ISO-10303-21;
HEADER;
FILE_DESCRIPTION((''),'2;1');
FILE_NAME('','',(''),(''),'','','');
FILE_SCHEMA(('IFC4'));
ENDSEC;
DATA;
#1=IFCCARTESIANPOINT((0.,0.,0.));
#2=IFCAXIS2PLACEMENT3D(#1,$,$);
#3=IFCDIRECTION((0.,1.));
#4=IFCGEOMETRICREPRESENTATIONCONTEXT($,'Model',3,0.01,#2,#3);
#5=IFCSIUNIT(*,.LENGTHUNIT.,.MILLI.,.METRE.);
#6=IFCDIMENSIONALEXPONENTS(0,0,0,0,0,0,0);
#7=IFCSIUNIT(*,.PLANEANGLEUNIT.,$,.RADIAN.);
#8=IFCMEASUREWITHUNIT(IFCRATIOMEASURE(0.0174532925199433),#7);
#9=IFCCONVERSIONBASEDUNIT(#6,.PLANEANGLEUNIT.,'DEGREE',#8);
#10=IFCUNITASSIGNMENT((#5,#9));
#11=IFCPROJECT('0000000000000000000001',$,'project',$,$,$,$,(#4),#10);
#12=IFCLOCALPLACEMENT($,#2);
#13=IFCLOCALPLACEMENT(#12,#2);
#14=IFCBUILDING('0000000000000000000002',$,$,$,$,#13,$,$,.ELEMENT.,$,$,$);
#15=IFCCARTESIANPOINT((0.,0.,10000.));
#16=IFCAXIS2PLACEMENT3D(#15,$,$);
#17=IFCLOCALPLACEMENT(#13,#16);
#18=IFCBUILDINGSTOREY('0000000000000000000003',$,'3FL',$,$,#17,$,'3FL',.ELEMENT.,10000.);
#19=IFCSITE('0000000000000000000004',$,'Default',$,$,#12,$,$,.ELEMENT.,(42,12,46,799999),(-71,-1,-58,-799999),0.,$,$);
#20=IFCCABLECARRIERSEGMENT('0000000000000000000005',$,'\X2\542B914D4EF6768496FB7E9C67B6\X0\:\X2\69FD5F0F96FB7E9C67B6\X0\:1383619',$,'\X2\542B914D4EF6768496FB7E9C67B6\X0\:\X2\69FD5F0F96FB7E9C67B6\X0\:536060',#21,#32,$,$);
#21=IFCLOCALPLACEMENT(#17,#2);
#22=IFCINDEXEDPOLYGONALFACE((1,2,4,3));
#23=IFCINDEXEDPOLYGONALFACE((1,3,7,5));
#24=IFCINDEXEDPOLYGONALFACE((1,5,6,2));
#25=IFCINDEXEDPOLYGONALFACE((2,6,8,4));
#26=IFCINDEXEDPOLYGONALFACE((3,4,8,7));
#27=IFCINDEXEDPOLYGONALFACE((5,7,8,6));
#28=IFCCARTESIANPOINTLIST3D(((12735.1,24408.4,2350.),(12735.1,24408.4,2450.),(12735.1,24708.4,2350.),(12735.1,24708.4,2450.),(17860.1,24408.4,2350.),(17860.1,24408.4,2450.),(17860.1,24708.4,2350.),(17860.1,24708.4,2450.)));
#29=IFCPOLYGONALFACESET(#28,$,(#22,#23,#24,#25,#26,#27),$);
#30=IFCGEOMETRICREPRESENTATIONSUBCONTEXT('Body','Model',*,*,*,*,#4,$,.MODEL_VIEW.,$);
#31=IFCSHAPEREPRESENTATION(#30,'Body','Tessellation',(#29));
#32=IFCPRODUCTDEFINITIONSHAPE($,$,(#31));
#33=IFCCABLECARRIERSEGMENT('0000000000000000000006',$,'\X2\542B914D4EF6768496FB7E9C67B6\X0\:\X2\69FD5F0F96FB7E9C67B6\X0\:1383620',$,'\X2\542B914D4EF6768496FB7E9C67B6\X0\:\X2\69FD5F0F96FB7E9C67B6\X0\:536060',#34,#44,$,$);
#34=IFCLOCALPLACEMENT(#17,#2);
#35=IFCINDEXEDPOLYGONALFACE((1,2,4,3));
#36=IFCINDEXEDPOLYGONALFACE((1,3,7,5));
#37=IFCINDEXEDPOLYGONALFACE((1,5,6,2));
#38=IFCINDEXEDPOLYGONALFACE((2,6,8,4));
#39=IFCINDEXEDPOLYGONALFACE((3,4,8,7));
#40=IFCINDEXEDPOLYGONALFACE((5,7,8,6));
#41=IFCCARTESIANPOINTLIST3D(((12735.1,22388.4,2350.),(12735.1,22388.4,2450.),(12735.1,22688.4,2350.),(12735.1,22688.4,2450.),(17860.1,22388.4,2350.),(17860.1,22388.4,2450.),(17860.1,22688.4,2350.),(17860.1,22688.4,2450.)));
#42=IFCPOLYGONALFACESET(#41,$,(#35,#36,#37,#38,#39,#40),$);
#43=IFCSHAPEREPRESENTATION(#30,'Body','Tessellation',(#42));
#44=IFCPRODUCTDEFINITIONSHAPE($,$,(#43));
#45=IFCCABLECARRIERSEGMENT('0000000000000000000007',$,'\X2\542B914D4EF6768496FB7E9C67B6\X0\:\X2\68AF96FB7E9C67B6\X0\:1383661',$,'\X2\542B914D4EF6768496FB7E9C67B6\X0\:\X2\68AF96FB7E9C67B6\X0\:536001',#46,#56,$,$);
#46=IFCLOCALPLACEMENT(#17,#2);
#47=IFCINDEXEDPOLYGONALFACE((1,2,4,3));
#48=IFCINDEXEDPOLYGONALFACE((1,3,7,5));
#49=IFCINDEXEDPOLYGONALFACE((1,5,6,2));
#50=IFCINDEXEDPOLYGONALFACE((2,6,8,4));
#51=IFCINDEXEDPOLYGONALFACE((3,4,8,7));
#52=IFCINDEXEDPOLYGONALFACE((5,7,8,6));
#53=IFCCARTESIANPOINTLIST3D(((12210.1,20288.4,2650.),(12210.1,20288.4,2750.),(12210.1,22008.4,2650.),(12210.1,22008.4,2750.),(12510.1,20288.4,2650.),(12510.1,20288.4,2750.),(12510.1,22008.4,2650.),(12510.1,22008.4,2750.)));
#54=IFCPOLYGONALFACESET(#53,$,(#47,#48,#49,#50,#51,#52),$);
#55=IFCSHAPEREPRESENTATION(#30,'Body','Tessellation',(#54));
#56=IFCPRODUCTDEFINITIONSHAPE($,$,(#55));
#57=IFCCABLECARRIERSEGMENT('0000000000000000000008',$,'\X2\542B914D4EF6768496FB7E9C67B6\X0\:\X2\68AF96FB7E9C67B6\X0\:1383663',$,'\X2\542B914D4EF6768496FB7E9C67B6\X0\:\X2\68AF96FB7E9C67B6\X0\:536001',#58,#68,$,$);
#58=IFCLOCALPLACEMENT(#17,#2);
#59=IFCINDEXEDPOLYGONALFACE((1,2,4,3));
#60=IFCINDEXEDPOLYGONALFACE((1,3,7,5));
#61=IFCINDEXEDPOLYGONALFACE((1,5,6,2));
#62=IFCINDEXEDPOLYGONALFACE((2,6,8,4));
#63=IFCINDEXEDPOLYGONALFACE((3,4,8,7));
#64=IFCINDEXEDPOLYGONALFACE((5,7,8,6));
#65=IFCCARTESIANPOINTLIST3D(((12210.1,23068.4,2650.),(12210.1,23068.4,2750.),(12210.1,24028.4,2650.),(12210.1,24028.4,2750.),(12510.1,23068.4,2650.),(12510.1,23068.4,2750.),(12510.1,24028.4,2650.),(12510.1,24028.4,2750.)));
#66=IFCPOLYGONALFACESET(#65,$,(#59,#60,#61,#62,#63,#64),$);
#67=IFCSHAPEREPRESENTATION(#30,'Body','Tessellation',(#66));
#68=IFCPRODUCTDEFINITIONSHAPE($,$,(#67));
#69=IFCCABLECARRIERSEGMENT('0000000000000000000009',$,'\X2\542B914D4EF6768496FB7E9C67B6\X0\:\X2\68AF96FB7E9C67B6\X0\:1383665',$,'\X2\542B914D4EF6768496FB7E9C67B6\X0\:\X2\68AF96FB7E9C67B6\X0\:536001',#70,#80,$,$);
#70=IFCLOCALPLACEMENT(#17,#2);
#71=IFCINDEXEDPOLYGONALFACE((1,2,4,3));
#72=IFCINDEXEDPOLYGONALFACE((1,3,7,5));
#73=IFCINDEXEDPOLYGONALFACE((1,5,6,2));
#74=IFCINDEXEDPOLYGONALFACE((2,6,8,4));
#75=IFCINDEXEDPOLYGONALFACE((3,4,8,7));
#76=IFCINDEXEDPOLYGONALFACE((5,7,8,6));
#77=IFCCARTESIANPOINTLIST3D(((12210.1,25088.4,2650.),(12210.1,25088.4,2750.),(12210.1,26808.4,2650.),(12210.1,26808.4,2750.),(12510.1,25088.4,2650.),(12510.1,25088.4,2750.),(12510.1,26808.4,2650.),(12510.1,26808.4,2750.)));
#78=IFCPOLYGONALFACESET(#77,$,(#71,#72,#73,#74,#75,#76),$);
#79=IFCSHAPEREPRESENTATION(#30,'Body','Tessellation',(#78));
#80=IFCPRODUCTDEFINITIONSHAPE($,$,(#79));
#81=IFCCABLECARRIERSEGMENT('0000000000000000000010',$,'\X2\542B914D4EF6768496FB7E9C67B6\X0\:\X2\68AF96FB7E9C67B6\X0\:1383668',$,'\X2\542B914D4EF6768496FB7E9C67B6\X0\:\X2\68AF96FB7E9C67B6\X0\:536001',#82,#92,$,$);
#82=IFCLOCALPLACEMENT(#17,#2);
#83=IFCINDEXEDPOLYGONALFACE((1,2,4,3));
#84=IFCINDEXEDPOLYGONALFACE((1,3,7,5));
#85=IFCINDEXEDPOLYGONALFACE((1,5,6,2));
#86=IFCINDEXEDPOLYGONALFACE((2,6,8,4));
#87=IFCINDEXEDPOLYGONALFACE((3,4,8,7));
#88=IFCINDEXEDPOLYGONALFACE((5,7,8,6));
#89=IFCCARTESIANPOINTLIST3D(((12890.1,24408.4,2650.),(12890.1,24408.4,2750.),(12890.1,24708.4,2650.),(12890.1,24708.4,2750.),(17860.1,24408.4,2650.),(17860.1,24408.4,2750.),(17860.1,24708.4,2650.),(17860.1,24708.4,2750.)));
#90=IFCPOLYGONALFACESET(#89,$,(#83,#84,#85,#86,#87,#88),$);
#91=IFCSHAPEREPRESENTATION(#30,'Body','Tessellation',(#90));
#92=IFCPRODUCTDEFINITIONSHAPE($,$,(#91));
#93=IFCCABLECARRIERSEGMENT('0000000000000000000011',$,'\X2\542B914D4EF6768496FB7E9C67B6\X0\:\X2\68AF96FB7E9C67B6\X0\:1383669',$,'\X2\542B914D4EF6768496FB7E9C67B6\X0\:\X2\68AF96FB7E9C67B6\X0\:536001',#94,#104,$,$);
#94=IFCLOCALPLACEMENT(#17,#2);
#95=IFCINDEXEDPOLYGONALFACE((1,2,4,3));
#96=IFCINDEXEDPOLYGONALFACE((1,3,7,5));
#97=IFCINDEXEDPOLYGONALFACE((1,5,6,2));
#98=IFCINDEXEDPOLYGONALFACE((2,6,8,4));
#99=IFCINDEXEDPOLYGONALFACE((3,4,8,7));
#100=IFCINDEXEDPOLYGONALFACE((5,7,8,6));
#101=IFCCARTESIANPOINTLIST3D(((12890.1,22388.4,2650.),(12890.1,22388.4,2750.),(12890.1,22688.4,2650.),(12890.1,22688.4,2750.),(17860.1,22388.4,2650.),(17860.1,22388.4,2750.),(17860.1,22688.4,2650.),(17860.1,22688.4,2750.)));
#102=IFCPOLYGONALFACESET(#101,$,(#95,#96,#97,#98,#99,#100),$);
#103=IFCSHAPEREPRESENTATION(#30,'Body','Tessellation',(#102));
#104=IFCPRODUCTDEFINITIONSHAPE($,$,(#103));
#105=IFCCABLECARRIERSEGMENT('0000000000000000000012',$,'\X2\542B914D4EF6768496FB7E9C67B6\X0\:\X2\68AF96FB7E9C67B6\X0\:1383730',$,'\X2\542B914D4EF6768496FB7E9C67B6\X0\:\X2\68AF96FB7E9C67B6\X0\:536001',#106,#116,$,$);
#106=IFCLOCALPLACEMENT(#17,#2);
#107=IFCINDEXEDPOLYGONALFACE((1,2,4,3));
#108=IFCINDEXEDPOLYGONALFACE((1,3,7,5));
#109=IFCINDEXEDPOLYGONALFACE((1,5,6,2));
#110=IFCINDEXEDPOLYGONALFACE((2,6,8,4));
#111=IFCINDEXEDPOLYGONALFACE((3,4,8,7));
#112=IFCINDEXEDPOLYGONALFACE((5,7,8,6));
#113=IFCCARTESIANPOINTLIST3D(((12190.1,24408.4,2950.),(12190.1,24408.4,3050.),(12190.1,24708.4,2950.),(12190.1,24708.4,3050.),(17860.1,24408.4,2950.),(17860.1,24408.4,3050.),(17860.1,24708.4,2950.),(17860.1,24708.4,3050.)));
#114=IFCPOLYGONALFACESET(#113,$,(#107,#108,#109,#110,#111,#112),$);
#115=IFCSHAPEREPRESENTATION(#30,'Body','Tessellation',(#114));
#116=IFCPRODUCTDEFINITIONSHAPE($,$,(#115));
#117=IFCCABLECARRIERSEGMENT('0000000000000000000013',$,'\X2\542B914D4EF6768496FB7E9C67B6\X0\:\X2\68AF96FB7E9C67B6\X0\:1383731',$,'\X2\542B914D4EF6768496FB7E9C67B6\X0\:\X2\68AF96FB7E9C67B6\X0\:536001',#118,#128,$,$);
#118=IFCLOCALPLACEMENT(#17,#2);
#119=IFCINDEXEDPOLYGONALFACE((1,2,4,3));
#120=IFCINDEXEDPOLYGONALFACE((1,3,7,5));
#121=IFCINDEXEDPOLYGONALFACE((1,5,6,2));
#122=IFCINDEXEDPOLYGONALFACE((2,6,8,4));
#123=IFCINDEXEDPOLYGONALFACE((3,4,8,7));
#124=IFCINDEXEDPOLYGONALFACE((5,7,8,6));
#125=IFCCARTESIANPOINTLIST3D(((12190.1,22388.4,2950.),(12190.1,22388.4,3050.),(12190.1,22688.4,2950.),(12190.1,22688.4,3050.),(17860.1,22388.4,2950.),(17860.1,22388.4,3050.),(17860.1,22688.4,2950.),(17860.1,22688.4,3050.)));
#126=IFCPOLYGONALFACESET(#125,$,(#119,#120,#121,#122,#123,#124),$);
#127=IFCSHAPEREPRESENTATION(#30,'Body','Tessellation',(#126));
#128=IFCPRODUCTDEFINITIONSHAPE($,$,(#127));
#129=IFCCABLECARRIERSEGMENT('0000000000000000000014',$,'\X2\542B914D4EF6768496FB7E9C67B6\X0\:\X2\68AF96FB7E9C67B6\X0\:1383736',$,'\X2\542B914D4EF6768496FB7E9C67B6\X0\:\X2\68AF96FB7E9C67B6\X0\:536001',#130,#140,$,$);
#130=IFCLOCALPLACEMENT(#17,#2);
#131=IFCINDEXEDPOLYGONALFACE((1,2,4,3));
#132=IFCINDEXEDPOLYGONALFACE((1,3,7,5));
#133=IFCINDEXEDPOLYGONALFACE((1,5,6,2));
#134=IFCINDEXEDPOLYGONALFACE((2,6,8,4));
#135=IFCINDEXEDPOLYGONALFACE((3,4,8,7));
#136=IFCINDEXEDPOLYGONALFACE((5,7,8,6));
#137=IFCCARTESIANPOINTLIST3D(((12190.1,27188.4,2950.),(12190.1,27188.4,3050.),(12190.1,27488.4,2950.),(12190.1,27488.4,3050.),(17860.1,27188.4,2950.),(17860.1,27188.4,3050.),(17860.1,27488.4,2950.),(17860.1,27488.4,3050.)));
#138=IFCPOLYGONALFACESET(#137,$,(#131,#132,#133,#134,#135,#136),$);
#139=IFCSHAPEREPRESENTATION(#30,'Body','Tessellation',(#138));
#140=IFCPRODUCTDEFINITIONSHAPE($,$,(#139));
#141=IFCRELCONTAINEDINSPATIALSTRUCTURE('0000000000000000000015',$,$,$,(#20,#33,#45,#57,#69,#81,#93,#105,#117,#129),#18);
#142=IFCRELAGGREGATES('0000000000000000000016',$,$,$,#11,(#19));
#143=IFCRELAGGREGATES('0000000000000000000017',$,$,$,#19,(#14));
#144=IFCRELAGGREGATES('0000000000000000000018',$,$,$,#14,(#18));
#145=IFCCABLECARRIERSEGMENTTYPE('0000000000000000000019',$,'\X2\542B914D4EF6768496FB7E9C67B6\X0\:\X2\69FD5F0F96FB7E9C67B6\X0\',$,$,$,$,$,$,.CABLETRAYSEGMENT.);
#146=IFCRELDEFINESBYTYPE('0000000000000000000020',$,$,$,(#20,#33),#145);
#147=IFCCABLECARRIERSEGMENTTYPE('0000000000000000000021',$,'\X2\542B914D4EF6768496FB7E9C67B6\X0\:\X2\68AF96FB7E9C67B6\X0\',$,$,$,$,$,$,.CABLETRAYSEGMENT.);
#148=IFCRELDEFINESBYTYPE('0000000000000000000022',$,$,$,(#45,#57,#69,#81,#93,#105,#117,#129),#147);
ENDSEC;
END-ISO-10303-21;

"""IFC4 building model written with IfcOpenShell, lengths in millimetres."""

from ifc_helpers import new_model, entity, si_unit, converted_unit, direction, frame, frame_2d, origin, place, context, subcontext, project, spatial, rectangle, extrude, type_object, element, save


model = new_model("IFC4")

# Units and contexts
model_context = context("Model", 3, precision=0.01, world=origin(), true_north=direction((0.0, 1.0)))
body_context = subcontext(model_context, "Body", "Model", "MODEL_VIEW")
ifc_project = project(units=[si_unit("LENGTHUNIT", "METRE", prefix="MILLI"), converted_unit("PLANEANGLEUNIT", "DEGREE", entity("IfcRatioMeasure", 0.0174532925199433), si_unit("PLANEANGLEUNIT", "RADIAN"), dimensions=[0, 0, 0, 0, 0, 0, 0])], contexts=[model_context])

# Site, building, storey
site_placement = place(None, origin())
site = spatial("IfcSite", under=ifc_project, at=site_placement, Name="Default", CompositionType="ELEMENT", RefLatitude=(42, 12, 46, 799999), RefLongitude=(-71, -1, -58, -799999), RefElevation=0.0)
building_placement = place(site_placement, origin())
building = spatial("IfcBuilding", under=site, at=building_placement, CompositionType="ELEMENT")
storey_placement = place(building_placement, frame((0.0, 0.0, 10000.0)))
storey = spatial("IfcBuildingStorey", under=building, at=storey_placement, Name="3FL", LongName="3FL", CompositionType="ELEMENT", Elevation=10000.0)

# Cable carrier segments
cable_carrier_segment_type_1 = type_object("IfcCableCarrierSegmentType", Name="含配件的電纜架:槽式電纜架", PredefinedType="CABLETRAYSEGMENT")
cable_carrier_segment_1_placement = place(storey_placement, frame((12735.1, 24408.4, 2350.0)))
element("IfcCableCarrierSegment", 1, at=cable_carrier_segment_1_placement, inside=storey, type_object=cable_carrier_segment_type_1, Name="含配件的電纜架:槽式電纜架:1383619", ObjectType="含配件的電纜架:槽式電纜架:536060", context=body_context, shape_type="SweptSolid", body=[
    extrude(rectangle(XDim=5125.0, YDim=300.0, at=frame_2d((0.0, 0.0), x_axis=(1.0, 0.0))), frame((2562.5, 150.0, 0.0), z_axis=(0.0, 0.0, 1.0), x_axis=(-1.0, 0.0, 0.0)), (0.0, 0.0, 1.0), 100.0),
])
cable_carrier_segment_2_placement = place(storey_placement, frame((12735.1, 22388.4, 2350.0)))
element("IfcCableCarrierSegment", 2, at=cable_carrier_segment_2_placement, inside=storey, type_object=cable_carrier_segment_type_1, Name="含配件的電纜架:槽式電纜架:1383620", ObjectType="含配件的電纜架:槽式電纜架:536060", context=body_context, shape_type="SweptSolid", body=[
    extrude(rectangle(XDim=5125.0, YDim=300.0, at=frame_2d((0.0, 0.0), x_axis=(1.0, 0.0))), frame((2562.5, 150.0, 0.0), z_axis=(0.0, 0.0, 1.0), x_axis=(-1.0, 0.0, 0.0)), (0.0, 0.0, 1.0), 100.0),
])
cable_carrier_segment_type_2 = type_object("IfcCableCarrierSegmentType", Name="含配件的電纜架:梯電纜架", PredefinedType="CABLETRAYSEGMENT")
cable_carrier_segment_3_placement = place(storey_placement, frame((12210.1, 20288.4, 2650.0)))
element("IfcCableCarrierSegment", 3, at=cable_carrier_segment_3_placement, inside=storey, type_object=cable_carrier_segment_type_2, Name="含配件的電纜架:梯電纜架:1383661", ObjectType="含配件的電纜架:梯電纜架:536001", context=body_context, shape_type="SweptSolid", body=[
    extrude(rectangle(XDim=1720.0, YDim=300.0, at=frame_2d((0.0, 0.0), x_axis=(1.0, 0.0))), frame((150.0, 860.0, 0.0), z_axis=(0.0, 0.0, 1.0), x_axis=(0.0, 1.0, 0.0)), (0.0, 0.0, 1.0), 100.0),
])
cable_carrier_segment_4_placement = place(storey_placement, frame((12210.1, 23068.4, 2650.0)))
element("IfcCableCarrierSegment", 4, at=cable_carrier_segment_4_placement, inside=storey, type_object=cable_carrier_segment_type_2, Name="含配件的電纜架:梯電纜架:1383663", ObjectType="含配件的電纜架:梯電纜架:536001", context=body_context, shape_type="SweptSolid", body=[
    extrude(rectangle(XDim=960.0, YDim=300.0, at=frame_2d((0.0, 0.0), x_axis=(1.0, 0.0))), frame((150.0, 480.0, 0.0), z_axis=(0.0, 0.0, 1.0), x_axis=(0.0, 1.0, 0.0)), (0.0, 0.0, 1.0), 100.0),
])
cable_carrier_segment_5_placement = place(storey_placement, frame((12210.1, 25088.4, 2650.0)))
element("IfcCableCarrierSegment", 5, at=cable_carrier_segment_5_placement, inside=storey, type_object=cable_carrier_segment_type_2, Name="含配件的電纜架:梯電纜架:1383665", ObjectType="含配件的電纜架:梯電纜架:536001", context=body_context, shape_type="SweptSolid", body=[
    extrude(rectangle(XDim=1720.0, YDim=300.0, at=frame_2d((0.0, 0.0), x_axis=(1.0, 0.0))), frame((150.0, 860.0, 0.0), z_axis=(0.0, 0.0, 1.0), x_axis=(0.0, 1.0, 0.0)), (0.0, 0.0, 1.0), 100.0),
])
cable_carrier_segment_6_placement = place(storey_placement, frame((12890.1, 24408.4, 2650.0)))
element("IfcCableCarrierSegment", 6, at=cable_carrier_segment_6_placement, inside=storey, type_object=cable_carrier_segment_type_2, Name="含配件的電纜架:梯電纜架:1383668", ObjectType="含配件的電纜架:梯電纜架:536001", context=body_context, shape_type="SweptSolid", body=[
    extrude(rectangle(XDim=4970.0, YDim=300.0, at=frame_2d((0.0, 0.0), x_axis=(1.0, 0.0))), frame((2485.0, 150.0, 0.0), z_axis=(0.0, 0.0, 1.0), x_axis=(-1.0, 0.0, 0.0)), (0.0, 0.0, 1.0), 100.0),
])
cable_carrier_segment_7_placement = place(storey_placement, frame((12890.1, 22388.4, 2650.0)))
element("IfcCableCarrierSegment", 7, at=cable_carrier_segment_7_placement, inside=storey, type_object=cable_carrier_segment_type_2, Name="含配件的電纜架:梯電纜架:1383669", ObjectType="含配件的電纜架:梯電纜架:536001", context=body_context, shape_type="SweptSolid", body=[
    extrude(rectangle(XDim=4970.0, YDim=300.0, at=frame_2d((0.0, 0.0), x_axis=(1.0, 0.0))), frame((2485.0, 150.0, 0.0), z_axis=(0.0, 0.0, 1.0), x_axis=(-1.0, 0.0, 0.0)), (0.0, 0.0, 1.0), 100.0),
])
cable_carrier_segment_8_placement = place(storey_placement, frame((12190.1, 24408.4, 2950.0)))
element("IfcCableCarrierSegment", 8, at=cable_carrier_segment_8_placement, inside=storey, type_object=cable_carrier_segment_type_2, Name="含配件的電纜架:梯電纜架:1383730", ObjectType="含配件的電纜架:梯電纜架:536001", context=body_context, shape_type="SweptSolid", body=[
    extrude(rectangle(XDim=5670.0, YDim=300.0, at=frame_2d((0.0, 0.0), x_axis=(1.0, 0.0))), frame((2835.0, 150.0, 0.0), z_axis=(0.0, 0.0, 1.0), x_axis=(-1.0, 0.0, 0.0)), (0.0, 0.0, 1.0), 100.0),
])
cable_carrier_segment_9_placement = place(storey_placement, frame((12190.1, 22388.4, 2950.0)))
element("IfcCableCarrierSegment", 9, at=cable_carrier_segment_9_placement, inside=storey, type_object=cable_carrier_segment_type_2, Name="含配件的電纜架:梯電纜架:1383731", ObjectType="含配件的電纜架:梯電纜架:536001", context=body_context, shape_type="SweptSolid", body=[
    extrude(rectangle(XDim=5670.0, YDim=300.0, at=frame_2d((0.0, 0.0), x_axis=(1.0, 0.0))), frame((2835.0, 150.0, 0.0), z_axis=(0.0, 0.0, 1.0), x_axis=(-1.0, 0.0, 0.0)), (0.0, 0.0, 1.0), 100.0),
])
cable_carrier_segment_10_placement = place(storey_placement, frame((12190.1, 27188.4, 2950.0)))
element("IfcCableCarrierSegment", 10, at=cable_carrier_segment_10_placement, inside=storey, type_object=cable_carrier_segment_type_2, Name="含配件的電纜架:梯電纜架:1383736", ObjectType="含配件的電纜架:梯電纜架:536001", context=body_context, shape_type="SweptSolid", body=[
    extrude(rectangle(XDim=5670.0, YDim=300.0, at=frame_2d((0.0, 0.0), x_axis=(1.0, 0.0))), frame((2835.0, 150.0, 0.0), z_axis=(0.0, 0.0, 1.0), x_axis=(-1.0, 0.0, 0.0)), (0.0, 0.0, 1.0), 100.0),
])

save(model, "model.ifc")
